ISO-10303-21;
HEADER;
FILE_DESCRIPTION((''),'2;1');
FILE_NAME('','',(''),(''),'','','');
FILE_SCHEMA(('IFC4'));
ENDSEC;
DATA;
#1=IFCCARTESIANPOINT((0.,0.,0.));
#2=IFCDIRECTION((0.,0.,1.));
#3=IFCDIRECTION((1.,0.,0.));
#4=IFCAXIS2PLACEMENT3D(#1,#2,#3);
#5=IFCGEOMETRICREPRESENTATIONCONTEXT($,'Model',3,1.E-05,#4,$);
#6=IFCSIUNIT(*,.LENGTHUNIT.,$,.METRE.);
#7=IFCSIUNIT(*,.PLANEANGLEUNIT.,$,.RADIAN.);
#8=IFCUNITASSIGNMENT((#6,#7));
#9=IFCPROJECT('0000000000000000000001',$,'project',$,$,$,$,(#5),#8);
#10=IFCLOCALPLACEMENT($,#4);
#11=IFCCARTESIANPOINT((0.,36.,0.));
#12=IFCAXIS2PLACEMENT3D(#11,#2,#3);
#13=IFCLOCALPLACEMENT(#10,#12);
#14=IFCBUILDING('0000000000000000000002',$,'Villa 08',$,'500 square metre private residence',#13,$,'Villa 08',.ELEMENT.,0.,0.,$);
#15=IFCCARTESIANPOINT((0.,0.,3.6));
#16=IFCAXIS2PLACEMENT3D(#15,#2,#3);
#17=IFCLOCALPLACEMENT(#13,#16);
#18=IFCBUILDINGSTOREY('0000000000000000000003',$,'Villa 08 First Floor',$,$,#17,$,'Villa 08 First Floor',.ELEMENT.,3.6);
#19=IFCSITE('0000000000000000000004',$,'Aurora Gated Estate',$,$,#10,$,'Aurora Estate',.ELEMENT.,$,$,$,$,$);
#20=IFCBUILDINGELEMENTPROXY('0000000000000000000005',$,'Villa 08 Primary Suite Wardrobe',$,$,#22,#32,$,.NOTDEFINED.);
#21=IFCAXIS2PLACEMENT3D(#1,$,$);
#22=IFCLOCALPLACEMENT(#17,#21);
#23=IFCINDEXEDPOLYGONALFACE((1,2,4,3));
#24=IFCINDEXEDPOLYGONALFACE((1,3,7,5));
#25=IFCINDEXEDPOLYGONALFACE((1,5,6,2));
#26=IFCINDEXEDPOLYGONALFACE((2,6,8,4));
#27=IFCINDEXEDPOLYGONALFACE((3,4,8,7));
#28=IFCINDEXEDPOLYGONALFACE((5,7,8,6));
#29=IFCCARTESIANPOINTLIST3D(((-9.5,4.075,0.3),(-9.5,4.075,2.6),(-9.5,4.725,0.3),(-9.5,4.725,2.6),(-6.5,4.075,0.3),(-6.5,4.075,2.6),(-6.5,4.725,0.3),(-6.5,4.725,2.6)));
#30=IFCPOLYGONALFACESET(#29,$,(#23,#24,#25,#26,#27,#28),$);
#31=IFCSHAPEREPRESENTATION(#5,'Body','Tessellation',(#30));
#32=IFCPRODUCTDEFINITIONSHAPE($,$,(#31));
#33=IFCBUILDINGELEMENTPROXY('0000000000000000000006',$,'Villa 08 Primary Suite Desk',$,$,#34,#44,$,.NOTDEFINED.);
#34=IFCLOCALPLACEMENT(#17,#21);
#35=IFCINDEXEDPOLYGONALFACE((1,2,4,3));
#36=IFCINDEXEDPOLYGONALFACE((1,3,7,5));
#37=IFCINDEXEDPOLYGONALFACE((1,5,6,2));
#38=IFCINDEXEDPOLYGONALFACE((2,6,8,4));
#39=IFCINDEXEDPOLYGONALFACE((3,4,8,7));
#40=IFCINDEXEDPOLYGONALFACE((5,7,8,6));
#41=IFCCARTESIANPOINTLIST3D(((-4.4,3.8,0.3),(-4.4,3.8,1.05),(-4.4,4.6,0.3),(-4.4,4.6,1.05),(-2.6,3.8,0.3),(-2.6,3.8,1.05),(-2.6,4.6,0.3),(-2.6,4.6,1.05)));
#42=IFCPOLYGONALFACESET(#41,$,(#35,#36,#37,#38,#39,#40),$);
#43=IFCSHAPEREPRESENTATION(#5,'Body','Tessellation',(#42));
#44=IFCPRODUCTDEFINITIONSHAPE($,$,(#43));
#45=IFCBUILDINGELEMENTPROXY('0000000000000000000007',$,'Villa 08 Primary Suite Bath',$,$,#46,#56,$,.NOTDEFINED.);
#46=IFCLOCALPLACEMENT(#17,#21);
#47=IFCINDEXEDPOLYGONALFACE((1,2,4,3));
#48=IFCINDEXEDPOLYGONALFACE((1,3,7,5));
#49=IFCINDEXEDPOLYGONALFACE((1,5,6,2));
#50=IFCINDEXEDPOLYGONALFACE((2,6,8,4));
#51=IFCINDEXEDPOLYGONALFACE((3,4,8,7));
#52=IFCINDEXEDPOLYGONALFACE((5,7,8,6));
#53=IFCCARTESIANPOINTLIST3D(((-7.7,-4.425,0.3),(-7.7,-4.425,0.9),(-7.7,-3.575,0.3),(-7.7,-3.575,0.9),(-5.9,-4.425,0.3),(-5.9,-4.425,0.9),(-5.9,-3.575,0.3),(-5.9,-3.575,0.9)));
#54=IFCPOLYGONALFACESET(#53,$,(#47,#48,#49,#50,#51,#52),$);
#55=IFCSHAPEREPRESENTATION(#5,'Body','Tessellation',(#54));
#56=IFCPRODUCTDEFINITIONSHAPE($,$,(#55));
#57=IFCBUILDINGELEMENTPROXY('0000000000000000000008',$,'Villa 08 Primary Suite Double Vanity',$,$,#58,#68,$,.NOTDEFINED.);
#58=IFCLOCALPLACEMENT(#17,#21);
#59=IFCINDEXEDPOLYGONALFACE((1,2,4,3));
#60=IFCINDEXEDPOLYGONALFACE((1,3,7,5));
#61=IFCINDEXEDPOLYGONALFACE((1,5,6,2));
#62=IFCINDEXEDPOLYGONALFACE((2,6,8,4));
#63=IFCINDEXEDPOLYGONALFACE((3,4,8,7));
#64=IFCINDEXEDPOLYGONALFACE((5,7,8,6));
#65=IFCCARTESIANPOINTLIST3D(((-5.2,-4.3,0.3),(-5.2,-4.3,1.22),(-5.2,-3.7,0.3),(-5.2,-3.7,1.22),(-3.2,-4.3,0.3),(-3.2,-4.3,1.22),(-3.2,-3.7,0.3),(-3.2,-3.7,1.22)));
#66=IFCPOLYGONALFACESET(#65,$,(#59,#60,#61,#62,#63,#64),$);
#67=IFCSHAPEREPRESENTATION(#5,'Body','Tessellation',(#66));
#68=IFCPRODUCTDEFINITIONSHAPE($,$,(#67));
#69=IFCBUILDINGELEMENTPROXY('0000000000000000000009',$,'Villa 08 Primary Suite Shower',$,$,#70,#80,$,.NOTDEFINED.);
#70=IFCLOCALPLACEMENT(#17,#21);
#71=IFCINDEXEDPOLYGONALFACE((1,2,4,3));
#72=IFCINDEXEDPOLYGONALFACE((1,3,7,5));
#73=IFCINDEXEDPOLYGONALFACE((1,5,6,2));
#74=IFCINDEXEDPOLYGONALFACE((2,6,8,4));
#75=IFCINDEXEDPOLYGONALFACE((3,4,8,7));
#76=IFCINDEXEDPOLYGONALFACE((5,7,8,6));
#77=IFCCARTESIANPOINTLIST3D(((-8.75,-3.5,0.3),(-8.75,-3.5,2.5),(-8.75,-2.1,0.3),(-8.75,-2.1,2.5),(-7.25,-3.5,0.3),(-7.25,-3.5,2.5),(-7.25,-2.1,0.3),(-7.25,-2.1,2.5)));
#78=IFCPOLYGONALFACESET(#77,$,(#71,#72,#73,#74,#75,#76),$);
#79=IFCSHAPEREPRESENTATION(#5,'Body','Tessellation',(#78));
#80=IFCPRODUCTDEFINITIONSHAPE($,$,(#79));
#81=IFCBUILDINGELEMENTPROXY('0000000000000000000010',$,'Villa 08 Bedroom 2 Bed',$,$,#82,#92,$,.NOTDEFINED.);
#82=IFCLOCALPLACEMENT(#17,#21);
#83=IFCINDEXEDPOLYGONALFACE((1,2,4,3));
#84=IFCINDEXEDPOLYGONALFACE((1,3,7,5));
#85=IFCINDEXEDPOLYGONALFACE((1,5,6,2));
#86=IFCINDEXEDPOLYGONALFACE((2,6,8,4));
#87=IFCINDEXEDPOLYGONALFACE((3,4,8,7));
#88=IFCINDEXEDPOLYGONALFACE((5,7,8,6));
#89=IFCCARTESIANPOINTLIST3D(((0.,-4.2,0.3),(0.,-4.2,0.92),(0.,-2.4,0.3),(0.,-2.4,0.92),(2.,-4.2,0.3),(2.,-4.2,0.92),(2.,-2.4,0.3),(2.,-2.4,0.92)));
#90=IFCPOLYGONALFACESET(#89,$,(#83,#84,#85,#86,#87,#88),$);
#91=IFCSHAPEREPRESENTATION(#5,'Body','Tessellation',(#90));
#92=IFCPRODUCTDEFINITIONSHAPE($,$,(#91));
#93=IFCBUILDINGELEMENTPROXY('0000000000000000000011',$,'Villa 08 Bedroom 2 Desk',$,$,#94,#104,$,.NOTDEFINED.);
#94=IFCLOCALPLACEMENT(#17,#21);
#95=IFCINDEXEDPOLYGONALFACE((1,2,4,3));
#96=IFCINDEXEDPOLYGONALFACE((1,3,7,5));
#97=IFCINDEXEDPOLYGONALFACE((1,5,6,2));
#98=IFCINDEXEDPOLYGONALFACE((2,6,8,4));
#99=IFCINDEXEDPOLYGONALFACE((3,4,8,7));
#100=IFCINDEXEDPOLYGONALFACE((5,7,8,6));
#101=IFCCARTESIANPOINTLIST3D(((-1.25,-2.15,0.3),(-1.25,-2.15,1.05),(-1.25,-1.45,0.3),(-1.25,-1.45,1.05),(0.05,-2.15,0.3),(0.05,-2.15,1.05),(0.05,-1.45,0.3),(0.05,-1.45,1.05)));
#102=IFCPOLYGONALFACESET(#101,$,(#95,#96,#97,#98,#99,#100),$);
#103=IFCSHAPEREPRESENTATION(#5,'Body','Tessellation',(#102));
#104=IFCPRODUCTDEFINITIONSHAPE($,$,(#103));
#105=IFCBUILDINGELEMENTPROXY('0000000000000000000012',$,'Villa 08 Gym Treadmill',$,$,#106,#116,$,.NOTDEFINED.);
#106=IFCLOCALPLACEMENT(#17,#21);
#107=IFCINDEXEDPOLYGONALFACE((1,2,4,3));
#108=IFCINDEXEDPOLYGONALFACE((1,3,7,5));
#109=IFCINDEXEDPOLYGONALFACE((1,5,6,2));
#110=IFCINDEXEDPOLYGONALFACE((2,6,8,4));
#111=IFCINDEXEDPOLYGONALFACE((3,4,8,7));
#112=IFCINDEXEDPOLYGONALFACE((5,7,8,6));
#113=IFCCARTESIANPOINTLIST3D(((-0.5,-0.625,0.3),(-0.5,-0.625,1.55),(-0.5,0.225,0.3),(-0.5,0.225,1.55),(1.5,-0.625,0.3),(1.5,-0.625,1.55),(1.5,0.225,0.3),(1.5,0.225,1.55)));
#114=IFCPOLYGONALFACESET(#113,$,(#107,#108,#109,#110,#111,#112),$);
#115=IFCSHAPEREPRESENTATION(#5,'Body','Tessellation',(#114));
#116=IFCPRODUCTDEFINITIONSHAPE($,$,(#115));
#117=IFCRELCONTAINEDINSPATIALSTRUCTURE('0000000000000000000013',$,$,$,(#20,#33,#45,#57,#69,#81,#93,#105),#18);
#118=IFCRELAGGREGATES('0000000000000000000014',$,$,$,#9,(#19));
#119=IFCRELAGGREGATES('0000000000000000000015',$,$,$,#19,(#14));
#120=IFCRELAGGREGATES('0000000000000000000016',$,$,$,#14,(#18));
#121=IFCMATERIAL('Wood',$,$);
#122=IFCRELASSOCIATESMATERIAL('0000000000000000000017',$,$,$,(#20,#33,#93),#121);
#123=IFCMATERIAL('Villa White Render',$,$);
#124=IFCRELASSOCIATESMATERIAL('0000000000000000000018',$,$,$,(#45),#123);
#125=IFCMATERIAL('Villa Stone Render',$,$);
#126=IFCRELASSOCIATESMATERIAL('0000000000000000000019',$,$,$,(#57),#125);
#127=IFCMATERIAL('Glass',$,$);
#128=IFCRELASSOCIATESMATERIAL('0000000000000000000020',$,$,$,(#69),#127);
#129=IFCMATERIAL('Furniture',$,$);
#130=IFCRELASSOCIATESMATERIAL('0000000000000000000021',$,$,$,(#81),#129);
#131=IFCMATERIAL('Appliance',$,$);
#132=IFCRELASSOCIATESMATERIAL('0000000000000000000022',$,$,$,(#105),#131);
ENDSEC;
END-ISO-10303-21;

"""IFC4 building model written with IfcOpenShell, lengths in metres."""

from ifc_helpers import new_model, si_unit, frame, origin_with_axes, origin_2d_with_axis, place, context, project, spatial, rectangle, extrude, material, element, save


model = new_model("IFC4")

# Units and contexts
model_context = context("Model", 3, precision=1e-05, world=origin_with_axes())
ifc_project = project(units=[si_unit("LENGTHUNIT", "METRE"), si_unit("PLANEANGLEUNIT", "RADIAN")], contexts=[model_context])

# Site, building, storey
site_placement = place(None, origin_with_axes())
site = spatial("IfcSite", under=ifc_project, at=site_placement, Name="Aurora Gated Estate", LongName="Aurora Estate", CompositionType="ELEMENT")
building_placement = place(site_placement, frame((0.0, 36.0, 0.0), z_axis=(0.0, 0.0, 1.0), x_axis=(1.0, 0.0, 0.0)))
building = spatial("IfcBuilding", under=site, at=building_placement, Name="Villa 08", ObjectType="500 square metre private residence", LongName="Villa 08", CompositionType="ELEMENT", ElevationOfRefHeight=0.0, ElevationOfTerrain=0.0)
storey_placement = place(building_placement, frame((0.0, 0.0, 3.6), z_axis=(0.0, 0.0, 1.0), x_axis=(1.0, 0.0, 0.0)))
storey = spatial("IfcBuildingStorey", under=building, at=storey_placement, Name="Villa 08 First Floor", LongName="Villa 08 First Floor", CompositionType="ELEMENT", Elevation=3.6)

# Building element proxies
ifc_material_1 = material(Name="Glass")
ifc_material_2 = material(Name="Furniture")
ifc_material_3 = material(Name="Wood")
proxy_1_placement = place(storey_placement, frame((-8.0, 4.4, 0.3), z_axis=(0.0, 0.0, 1.0), x_axis=(1.0, 0.0, 0.0)))
element("IfcBuildingElementProxy", 1, at=proxy_1_placement, inside=storey, material=ifc_material_3, Name="Villa 08 Primary Suite Wardrobe", PredefinedType="NOTDEFINED", context=model_context, shape_type="SweptSolid", body=[
    extrude(rectangle(XDim=3.0, YDim=0.65, at=origin_2d_with_axis()), origin_with_axes(), (0.0, 0.0, 1.0), 2.3),
])
proxy_2_placement = place(storey_placement, frame((-3.5, 4.2, 0.3), z_axis=(0.0, 0.0, 1.0), x_axis=(1.0, 0.0, 0.0)))
element("IfcBuildingElementProxy", 2, at=proxy_2_placement, inside=storey, material=ifc_material_3, Name="Villa 08 Primary Suite Desk", PredefinedType="NOTDEFINED", context=model_context, shape_type="SweptSolid", body=[
    extrude(rectangle(XDim=1.8, YDim=0.8, at=origin_2d_with_axis()), origin_with_axes(), (0.0, 0.0, 1.0), 0.75),
])
ifc_material_4 = material(Name="Villa White Render")
proxy_3_placement = place(storey_placement, frame((-6.8, -4.0, 0.3), z_axis=(0.0, 0.0, 1.0), x_axis=(1.0, 0.0, 0.0)))
element("IfcBuildingElementProxy", 3, at=proxy_3_placement, inside=storey, material=ifc_material_4, Name="Villa 08 Primary Suite Bath", PredefinedType="NOTDEFINED", context=model_context, shape_type="SweptSolid", body=[
    extrude(rectangle(XDim=1.8, YDim=0.85, at=origin_2d_with_axis()), origin_with_axes(), (0.0, 0.0, 1.0), 0.6),
])
ifc_material_5 = material(Name="Villa Stone Render")
proxy_4_placement = place(storey_placement, frame((-4.2, -4.0, 0.3), z_axis=(0.0, 0.0, 1.0), x_axis=(1.0, 0.0, 0.0)))
element("IfcBuildingElementProxy", 4, at=proxy_4_placement, inside=storey, material=ifc_material_5, Name="Villa 08 Primary Suite Double Vanity", PredefinedType="NOTDEFINED", context=model_context, shape_type="SweptSolid", body=[
    extrude(rectangle(XDim=2.0, YDim=0.6, at=origin_2d_with_axis()), origin_with_axes(), (0.0, 0.0, 1.0), 0.92),
])
proxy_5_placement = place(storey_placement, frame((-8.0, -2.8, 0.3), z_axis=(0.0, 0.0, 1.0), x_axis=(1.0, 0.0, 0.0)))
element("IfcBuildingElementProxy", 5, at=proxy_5_placement, inside=storey, material=ifc_material_1, Name="Villa 08 Primary Suite Shower", PredefinedType="NOTDEFINED", context=model_context, shape_type="SweptSolid", body=[
    extrude(rectangle(XDim=1.5, YDim=1.4, at=origin_2d_with_axis()), origin_with_axes(), (0.0, 0.0, 1.0), 2.2),
])
proxy_6_placement = place(storey_placement, frame((1.0, -3.3, 0.3), z_axis=(0.0, 0.0, 1.0), x_axis=(1.0, 0.0, 0.0)))
element("IfcBuildingElementProxy", 6, at=proxy_6_placement, inside=storey, material=ifc_material_2, Name="Villa 08 Bedroom 2 Bed", PredefinedType="NOTDEFINED", context=model_context, shape_type="SweptSolid", body=[
    extrude(rectangle(XDim=2.0, YDim=1.8, at=origin_2d_with_axis()), origin_with_axes(), (0.0, 0.0, 1.0), 0.62),
])
proxy_7_placement = place(storey_placement, frame((-0.6, -1.8, 0.3), z_axis=(0.0, 0.0, 1.0), x_axis=(1.0, 0.0, 0.0)))
element("IfcBuildingElementProxy", 7, at=proxy_7_placement, inside=storey, material=ifc_material_3, Name="Villa 08 Bedroom 2 Desk", PredefinedType="NOTDEFINED", context=model_context, shape_type="SweptSolid", body=[
    extrude(rectangle(XDim=1.3, YDim=0.7, at=origin_2d_with_axis()), origin_with_axes(), (0.0, 0.0, 1.0), 0.75),
])
ifc_material_6 = material(Name="Appliance")
proxy_8_placement = place(storey_placement, frame((0.5, -0.2, 0.3), z_axis=(0.0, 0.0, 1.0), x_axis=(1.0, 0.0, 0.0)))
element("IfcBuildingElementProxy", 8, at=proxy_8_placement, inside=storey, material=ifc_material_6, Name="Villa 08 Gym Treadmill", PredefinedType="NOTDEFINED", context=model_context, shape_type="SweptSolid", body=[
    extrude(rectangle(XDim=2.0, YDim=0.85, at=origin_2d_with_axis()), origin_with_axes(), (0.0, 0.0, 1.0), 1.25),
])

save(model, "model.ifc")
